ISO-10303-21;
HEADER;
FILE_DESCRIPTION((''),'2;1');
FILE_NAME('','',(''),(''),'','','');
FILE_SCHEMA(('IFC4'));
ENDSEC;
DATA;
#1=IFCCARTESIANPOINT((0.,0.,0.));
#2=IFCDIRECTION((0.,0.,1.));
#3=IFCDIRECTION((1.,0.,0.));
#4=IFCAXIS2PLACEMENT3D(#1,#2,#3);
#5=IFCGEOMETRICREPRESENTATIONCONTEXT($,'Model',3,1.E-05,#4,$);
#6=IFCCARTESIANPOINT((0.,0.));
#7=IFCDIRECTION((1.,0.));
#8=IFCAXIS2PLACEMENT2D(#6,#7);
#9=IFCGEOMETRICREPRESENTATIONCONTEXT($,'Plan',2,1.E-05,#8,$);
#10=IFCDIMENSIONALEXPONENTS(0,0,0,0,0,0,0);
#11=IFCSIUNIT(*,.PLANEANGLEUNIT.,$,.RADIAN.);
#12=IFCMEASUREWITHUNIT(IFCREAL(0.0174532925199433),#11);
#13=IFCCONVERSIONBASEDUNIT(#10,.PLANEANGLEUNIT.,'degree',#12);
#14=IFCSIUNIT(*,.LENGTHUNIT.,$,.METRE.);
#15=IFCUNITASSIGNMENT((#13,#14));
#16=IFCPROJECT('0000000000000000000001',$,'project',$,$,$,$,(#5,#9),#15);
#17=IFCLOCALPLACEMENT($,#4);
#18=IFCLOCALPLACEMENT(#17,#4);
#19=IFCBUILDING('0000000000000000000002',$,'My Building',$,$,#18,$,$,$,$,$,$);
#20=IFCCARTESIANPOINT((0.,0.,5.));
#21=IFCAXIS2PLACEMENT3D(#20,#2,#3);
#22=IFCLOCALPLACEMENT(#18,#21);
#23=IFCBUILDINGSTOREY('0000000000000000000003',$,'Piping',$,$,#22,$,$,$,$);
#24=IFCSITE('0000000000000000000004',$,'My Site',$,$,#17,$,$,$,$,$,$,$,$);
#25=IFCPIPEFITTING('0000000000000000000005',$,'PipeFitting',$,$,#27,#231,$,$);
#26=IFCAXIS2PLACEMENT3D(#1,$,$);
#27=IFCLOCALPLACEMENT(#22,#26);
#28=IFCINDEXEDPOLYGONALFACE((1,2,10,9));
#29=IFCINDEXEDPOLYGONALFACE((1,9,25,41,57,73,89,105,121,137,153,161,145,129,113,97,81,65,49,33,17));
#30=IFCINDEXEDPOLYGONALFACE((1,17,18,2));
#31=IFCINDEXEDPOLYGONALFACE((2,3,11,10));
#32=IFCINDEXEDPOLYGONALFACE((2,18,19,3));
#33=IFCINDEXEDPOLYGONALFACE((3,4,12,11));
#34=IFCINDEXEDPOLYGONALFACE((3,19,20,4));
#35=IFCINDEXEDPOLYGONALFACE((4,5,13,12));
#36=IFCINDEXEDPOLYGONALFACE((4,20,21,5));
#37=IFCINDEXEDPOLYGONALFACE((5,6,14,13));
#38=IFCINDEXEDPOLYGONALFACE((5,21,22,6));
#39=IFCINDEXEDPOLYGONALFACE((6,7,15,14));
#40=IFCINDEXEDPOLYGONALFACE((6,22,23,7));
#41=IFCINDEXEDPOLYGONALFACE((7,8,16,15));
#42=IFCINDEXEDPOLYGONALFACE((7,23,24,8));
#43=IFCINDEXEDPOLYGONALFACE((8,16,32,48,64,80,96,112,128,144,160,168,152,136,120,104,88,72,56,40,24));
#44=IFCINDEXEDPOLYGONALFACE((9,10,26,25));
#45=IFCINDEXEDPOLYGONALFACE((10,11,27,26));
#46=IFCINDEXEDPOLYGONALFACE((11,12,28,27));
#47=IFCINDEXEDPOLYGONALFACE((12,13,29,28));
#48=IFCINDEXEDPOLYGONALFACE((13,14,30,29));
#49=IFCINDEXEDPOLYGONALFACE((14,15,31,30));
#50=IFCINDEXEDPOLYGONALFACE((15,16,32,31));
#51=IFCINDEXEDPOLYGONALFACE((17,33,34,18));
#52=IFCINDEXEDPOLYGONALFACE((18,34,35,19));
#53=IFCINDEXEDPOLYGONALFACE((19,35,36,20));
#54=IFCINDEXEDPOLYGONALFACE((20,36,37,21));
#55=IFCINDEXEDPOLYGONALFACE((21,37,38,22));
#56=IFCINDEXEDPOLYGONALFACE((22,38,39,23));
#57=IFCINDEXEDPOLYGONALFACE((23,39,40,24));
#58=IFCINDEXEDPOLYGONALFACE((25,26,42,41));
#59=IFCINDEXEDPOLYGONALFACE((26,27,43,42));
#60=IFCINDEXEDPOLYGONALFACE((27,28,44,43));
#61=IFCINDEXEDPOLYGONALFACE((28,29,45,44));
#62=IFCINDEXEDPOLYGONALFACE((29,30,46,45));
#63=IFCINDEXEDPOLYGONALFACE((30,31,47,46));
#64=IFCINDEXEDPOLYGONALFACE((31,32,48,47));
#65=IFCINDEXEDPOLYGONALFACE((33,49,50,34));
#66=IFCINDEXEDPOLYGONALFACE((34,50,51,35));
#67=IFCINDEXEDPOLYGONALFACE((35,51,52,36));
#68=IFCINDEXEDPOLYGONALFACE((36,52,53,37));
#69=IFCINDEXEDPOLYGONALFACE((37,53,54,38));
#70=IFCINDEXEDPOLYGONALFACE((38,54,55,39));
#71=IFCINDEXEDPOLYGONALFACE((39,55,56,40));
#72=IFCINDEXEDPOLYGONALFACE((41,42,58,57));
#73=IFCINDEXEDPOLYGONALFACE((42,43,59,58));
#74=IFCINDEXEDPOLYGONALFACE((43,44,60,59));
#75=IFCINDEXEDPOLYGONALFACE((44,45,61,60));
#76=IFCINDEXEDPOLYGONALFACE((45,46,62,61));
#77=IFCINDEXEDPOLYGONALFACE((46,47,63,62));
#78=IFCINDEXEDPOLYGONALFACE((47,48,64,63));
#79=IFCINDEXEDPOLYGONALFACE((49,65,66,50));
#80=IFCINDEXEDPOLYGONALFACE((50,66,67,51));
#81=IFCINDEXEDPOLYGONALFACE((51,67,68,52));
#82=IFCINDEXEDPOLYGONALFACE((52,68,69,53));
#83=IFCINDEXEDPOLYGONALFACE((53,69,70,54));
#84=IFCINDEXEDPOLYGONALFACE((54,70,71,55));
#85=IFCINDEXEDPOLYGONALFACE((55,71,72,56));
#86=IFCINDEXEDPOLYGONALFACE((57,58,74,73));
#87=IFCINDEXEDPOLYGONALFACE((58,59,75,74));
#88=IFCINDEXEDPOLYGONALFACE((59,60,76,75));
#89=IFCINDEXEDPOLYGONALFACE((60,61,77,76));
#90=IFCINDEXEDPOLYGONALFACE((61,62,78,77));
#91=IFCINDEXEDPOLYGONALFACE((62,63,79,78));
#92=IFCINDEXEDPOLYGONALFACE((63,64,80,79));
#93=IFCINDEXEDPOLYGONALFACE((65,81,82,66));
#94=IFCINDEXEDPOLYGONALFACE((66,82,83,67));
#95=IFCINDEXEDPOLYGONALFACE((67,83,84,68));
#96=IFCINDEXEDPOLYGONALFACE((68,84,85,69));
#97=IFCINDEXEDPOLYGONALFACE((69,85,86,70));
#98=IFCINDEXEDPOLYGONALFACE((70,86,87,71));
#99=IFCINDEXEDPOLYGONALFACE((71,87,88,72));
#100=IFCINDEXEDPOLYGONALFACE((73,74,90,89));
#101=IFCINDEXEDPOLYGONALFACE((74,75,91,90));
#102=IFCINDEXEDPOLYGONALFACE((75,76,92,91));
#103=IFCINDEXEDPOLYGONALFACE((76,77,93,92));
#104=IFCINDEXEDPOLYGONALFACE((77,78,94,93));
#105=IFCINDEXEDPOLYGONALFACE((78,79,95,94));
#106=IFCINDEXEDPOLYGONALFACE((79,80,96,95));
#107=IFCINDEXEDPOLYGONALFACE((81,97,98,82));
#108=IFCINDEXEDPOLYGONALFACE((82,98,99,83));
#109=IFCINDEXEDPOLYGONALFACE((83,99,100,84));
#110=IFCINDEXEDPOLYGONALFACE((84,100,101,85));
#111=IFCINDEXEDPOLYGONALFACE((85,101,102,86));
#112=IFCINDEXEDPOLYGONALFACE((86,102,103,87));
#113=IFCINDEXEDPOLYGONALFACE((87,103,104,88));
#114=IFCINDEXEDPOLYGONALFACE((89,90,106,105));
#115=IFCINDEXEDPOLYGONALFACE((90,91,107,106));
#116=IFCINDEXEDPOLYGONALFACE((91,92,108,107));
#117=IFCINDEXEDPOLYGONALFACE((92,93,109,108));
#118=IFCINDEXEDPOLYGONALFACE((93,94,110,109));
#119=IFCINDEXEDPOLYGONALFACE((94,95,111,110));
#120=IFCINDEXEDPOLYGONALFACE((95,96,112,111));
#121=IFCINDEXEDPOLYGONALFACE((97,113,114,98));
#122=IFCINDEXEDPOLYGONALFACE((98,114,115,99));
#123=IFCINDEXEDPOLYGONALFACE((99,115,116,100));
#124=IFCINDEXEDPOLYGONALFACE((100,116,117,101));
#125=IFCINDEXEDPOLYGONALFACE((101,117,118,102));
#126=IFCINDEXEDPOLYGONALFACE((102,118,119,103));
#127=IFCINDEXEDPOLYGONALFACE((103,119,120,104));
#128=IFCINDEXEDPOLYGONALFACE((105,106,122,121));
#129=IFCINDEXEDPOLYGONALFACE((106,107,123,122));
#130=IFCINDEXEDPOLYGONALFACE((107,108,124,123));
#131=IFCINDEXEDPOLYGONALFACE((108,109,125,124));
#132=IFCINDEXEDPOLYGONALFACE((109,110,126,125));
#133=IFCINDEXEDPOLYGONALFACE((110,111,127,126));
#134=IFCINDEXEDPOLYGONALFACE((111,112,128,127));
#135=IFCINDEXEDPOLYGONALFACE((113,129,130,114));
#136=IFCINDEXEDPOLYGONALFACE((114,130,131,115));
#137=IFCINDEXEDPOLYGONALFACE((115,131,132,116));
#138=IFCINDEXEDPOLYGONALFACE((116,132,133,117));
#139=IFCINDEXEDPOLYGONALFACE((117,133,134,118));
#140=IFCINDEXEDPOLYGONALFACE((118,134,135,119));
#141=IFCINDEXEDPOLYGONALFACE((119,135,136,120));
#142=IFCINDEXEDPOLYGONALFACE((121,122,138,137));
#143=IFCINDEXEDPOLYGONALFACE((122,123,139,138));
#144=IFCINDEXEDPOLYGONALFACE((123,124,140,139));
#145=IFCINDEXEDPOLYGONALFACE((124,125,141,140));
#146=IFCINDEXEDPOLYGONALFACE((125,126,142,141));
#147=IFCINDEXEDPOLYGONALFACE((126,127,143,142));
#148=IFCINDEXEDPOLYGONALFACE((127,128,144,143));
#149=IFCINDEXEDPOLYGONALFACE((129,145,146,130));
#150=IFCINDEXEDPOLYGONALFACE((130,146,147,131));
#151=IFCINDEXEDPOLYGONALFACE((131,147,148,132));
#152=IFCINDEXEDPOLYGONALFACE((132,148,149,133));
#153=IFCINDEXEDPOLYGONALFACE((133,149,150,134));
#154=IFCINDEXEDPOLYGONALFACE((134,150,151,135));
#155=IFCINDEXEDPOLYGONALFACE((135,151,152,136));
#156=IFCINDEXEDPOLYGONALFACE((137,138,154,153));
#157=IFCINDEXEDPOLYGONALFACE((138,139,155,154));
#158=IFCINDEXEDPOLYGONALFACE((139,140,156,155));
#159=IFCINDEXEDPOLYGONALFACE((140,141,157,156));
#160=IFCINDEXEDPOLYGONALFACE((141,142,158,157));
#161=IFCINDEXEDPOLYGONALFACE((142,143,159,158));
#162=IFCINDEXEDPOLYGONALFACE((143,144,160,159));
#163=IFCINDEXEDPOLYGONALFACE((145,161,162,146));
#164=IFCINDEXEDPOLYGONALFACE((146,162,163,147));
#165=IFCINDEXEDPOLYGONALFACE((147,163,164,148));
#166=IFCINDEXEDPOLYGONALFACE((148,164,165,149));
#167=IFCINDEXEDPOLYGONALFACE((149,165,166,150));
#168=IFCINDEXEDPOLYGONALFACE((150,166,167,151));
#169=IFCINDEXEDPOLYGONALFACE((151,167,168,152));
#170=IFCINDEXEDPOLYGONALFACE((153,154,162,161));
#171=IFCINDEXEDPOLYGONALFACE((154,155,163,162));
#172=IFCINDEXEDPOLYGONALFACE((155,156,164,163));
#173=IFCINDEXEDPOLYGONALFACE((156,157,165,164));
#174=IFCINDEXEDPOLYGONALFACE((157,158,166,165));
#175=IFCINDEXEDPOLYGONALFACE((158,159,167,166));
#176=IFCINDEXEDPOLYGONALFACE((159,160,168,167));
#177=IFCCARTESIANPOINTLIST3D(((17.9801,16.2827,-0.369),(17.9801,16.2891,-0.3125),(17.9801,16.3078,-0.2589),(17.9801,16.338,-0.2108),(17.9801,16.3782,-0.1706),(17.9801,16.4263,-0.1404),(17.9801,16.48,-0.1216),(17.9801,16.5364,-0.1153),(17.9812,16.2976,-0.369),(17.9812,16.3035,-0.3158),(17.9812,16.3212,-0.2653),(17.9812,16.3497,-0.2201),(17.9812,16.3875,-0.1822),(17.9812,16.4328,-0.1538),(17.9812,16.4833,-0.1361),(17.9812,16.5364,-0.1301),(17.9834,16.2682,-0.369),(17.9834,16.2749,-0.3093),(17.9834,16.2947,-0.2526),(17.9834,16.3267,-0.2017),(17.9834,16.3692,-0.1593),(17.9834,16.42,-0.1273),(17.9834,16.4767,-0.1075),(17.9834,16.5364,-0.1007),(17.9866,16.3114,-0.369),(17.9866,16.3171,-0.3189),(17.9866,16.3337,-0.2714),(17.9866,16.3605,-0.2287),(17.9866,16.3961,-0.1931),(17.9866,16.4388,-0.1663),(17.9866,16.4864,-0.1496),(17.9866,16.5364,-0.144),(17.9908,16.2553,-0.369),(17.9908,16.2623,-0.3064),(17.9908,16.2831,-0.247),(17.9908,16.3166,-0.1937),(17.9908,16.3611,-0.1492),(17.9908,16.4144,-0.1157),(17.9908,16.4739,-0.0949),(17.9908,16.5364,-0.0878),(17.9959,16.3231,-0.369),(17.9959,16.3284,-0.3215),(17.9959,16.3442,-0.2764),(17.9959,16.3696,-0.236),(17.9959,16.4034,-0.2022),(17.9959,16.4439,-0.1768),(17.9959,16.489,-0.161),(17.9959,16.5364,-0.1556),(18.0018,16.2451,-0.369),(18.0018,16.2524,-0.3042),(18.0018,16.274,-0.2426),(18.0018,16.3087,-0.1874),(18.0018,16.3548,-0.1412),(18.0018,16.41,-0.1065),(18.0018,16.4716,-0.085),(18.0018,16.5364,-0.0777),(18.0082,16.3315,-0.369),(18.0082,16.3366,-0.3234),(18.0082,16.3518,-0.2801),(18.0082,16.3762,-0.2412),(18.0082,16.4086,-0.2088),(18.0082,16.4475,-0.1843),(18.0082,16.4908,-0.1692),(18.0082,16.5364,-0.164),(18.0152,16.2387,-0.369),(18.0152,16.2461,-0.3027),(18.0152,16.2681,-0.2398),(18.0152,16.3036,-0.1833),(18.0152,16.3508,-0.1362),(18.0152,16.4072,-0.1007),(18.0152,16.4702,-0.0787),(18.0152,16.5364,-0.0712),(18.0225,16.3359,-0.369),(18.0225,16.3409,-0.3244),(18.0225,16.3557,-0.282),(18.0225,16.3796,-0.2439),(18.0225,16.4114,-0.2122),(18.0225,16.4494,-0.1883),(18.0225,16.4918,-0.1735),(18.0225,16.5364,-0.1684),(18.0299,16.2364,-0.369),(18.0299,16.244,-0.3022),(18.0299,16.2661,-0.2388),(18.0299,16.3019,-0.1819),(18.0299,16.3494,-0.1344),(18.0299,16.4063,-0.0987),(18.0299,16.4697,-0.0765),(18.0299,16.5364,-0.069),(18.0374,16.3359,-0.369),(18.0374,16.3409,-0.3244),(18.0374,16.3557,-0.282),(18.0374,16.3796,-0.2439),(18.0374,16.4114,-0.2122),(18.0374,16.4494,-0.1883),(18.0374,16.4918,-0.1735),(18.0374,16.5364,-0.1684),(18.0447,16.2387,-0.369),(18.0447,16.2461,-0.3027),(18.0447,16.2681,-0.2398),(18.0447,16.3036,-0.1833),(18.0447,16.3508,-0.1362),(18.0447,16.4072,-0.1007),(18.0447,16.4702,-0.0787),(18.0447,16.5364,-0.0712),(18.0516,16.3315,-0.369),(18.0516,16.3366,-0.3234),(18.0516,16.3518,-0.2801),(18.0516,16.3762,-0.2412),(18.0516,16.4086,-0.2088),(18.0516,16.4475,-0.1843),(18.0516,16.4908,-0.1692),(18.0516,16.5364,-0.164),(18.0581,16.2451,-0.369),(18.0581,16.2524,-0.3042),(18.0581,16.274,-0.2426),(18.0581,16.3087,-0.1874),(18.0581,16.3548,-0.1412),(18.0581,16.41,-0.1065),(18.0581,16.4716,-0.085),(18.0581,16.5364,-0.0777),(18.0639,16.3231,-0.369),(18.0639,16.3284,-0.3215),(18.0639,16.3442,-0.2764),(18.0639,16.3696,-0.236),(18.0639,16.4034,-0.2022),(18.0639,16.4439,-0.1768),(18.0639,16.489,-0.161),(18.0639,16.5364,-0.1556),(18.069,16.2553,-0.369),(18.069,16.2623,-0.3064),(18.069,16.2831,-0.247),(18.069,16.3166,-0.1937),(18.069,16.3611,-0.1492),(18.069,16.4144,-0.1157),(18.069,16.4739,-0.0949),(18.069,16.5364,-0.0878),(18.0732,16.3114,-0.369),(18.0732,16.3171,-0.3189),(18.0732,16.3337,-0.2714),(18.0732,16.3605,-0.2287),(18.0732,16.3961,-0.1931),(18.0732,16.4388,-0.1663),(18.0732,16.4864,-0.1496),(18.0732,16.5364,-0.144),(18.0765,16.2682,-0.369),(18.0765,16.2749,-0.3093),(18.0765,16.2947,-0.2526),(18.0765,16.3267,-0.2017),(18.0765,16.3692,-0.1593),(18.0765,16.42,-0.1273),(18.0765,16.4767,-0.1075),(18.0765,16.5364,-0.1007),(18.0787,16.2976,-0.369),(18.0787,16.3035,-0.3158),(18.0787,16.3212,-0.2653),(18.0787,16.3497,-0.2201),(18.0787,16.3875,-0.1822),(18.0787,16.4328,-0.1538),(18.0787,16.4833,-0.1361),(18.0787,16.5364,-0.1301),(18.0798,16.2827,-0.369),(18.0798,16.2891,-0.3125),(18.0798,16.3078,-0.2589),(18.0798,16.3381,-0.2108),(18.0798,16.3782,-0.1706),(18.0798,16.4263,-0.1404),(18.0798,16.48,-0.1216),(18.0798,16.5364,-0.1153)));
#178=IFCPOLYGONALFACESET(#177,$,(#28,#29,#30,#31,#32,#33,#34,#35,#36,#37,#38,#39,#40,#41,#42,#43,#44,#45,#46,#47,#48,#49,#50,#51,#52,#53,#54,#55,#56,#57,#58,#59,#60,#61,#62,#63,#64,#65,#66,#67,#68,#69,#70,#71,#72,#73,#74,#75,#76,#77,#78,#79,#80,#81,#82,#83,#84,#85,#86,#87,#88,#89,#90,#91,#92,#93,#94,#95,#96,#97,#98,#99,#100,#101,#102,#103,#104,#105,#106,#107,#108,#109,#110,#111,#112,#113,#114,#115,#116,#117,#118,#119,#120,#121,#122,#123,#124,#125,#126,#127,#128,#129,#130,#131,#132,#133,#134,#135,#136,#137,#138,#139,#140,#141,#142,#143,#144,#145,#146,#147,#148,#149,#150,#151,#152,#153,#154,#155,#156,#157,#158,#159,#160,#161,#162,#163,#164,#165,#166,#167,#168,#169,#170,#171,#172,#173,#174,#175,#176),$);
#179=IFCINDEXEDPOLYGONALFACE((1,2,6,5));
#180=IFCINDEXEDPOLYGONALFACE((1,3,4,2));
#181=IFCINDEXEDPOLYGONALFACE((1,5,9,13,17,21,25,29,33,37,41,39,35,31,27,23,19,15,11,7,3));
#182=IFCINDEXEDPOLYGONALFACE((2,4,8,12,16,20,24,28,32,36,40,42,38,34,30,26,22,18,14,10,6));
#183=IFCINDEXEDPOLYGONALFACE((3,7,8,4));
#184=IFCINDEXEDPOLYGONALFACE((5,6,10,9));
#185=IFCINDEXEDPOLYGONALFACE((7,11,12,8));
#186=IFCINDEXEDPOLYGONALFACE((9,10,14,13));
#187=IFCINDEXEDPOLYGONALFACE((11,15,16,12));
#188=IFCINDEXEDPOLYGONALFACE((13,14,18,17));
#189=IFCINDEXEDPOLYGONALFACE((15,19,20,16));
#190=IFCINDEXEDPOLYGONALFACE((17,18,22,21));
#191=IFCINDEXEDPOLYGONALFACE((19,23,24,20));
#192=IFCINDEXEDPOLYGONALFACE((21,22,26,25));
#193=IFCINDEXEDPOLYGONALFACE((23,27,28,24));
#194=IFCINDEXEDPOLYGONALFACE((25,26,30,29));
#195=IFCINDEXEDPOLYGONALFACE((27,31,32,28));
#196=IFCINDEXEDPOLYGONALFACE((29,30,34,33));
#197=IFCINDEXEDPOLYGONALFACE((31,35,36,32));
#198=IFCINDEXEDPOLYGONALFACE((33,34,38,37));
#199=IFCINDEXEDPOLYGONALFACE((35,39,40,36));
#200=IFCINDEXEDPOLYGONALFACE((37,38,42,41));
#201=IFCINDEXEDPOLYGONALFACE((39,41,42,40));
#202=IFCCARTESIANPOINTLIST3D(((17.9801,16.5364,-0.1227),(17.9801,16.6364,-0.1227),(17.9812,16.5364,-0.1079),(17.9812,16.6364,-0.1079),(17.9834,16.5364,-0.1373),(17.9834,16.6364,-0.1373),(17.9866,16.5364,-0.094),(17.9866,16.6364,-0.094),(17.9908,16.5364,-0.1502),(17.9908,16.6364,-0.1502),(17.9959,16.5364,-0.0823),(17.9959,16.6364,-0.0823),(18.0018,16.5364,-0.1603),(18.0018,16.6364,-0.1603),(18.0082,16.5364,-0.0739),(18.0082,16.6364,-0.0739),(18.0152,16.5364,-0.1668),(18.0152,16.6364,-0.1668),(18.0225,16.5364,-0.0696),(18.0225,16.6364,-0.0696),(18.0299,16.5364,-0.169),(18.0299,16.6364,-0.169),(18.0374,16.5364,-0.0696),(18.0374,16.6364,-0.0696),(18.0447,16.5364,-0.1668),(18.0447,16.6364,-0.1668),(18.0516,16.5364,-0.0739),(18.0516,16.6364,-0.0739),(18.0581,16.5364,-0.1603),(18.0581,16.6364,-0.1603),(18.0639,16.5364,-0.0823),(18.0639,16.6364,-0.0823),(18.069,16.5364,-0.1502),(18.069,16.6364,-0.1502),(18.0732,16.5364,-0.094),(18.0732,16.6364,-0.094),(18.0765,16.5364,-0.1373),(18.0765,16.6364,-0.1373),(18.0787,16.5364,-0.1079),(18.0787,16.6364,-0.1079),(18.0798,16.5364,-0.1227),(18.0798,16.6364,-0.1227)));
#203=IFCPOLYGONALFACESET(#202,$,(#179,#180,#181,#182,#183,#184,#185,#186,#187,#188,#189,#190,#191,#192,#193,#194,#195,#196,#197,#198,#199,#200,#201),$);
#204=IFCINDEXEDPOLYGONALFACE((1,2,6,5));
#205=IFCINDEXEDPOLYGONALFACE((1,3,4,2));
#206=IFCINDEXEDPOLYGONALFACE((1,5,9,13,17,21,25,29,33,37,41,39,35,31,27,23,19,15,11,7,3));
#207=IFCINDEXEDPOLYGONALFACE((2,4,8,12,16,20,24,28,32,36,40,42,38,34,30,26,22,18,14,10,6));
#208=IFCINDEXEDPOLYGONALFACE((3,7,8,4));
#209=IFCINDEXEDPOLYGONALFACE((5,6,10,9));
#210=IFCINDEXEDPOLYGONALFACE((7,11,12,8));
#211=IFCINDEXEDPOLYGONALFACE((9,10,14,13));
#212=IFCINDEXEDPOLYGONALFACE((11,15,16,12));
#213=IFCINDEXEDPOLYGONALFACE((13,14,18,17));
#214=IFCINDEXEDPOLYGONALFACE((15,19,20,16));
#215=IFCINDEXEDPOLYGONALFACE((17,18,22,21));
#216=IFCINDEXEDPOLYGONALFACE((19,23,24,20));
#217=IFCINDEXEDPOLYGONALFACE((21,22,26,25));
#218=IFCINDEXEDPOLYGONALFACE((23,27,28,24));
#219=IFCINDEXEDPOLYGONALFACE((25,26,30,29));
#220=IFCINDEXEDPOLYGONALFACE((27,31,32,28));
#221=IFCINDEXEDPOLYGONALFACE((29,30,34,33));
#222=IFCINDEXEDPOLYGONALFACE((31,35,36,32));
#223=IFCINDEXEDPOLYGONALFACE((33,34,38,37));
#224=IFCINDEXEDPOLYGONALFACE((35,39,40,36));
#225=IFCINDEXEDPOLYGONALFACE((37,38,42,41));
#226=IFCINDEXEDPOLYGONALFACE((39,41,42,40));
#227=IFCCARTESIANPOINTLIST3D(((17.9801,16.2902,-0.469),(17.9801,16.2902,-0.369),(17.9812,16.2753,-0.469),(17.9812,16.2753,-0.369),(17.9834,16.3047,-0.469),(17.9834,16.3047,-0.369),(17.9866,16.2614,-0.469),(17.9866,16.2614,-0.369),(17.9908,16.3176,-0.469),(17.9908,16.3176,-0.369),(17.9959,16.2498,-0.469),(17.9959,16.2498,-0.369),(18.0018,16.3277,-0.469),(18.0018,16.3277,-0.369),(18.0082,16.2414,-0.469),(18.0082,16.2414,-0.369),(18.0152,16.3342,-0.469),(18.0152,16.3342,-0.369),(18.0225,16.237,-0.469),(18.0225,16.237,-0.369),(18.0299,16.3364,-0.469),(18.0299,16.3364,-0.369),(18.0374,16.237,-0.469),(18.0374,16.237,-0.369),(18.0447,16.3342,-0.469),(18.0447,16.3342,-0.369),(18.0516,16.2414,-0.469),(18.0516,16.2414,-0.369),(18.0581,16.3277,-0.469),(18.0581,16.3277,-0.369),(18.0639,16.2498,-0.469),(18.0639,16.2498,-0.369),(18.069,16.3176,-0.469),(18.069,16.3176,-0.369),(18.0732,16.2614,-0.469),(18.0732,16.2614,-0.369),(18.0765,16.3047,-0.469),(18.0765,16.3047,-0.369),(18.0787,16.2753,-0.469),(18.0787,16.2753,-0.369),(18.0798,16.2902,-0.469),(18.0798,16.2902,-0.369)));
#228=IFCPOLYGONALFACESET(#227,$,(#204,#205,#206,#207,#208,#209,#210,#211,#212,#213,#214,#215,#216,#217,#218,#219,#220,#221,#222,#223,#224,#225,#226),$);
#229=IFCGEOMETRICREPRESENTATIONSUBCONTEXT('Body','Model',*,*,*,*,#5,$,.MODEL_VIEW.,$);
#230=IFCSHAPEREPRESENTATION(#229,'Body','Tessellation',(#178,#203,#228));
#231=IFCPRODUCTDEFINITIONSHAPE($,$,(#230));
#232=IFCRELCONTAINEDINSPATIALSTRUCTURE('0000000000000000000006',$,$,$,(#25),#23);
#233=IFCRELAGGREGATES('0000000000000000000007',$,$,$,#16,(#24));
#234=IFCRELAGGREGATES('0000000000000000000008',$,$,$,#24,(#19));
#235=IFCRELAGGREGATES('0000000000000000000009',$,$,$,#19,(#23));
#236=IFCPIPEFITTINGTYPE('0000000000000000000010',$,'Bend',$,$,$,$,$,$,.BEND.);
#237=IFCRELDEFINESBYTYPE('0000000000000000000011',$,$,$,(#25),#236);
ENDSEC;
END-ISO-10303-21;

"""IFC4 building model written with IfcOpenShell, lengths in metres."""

from ifc_helpers import new_model, entity, si_unit, converted_unit, frame, origin_with_axes, origin_2d_with_axis, place, context, subcontext, project, spatial, circle, extrude, source, transform, mapped, type_object, type_shapes, element, save


model = new_model("IFC4")

# Units and contexts
model_context = context("Model", 3, precision=1e-05, world=origin_with_axes())
plan_context = context("Plan", 2, precision=1e-05, world=origin_2d_with_axis())
body_context = subcontext(model_context, "Body", "Model", "MODEL_VIEW")
ifc_project = project(units=[converted_unit("PLANEANGLEUNIT", "degree", entity("IfcReal", 0.0174532925199433), si_unit("PLANEANGLEUNIT", "RADIAN"), dimensions=[0, 0, 0, 0, 0, 0, 0]), si_unit("LENGTHUNIT", "METRE")], contexts=[model_context, plan_context])

# Site, building, storey
site_placement = place(None, origin_with_axes())
site = spatial("IfcSite", under=ifc_project, at=site_placement, Name="My Site")
building_placement = place(site_placement, origin_with_axes())
building = spatial("IfcBuilding", under=site, at=building_placement, Name="My Building")
storey_placement = place(building_placement, frame((0.0, 0.0, 5.0), z_axis=(0.0, 0.0, 1.0), x_axis=(1.0, 0.0, 0.0)))
storey = spatial("IfcBuildingStorey", under=building, at=storey_placement, Name="Piping")

# Pipe fitting
pipe_fitting_type_1 = type_object("IfcPipeFittingType", Name="Bend", PredefinedType="BEND")
shared_shape = source(origin_with_axes(), body_context, "Body", "SolidModel", [
    entity("IfcSweptDiskSolid", entity("IfcIndexedPolyCurve", entity("IfcCartesianPointList3D", [[0.0, 0.0, -0.1], [0.0732, 0.0, -0.2768], [0.25, 0.0, -0.35]]), [entity("IfcArcIndex", [1, 2, 3])]), 0.05),
    extrude(circle(Radius=0.05), origin_with_axes(), (0.0, 0.0, -1.0), 0.1),
    extrude(circle(Radius=0.05), frame((0.25, 0.0, -0.35), z_axis=(1.0, 0.0, 0.0), x_axis=(0.0, 0.0, 1.0)), (0.0, 0.0, 1.0), 0.1),
])
type_shapes(pipe_fitting_type_1, [shared_shape])
for number, where, z_axis, x_axis, name in (
    (1, (18.0299, 16.6364, -0.119), (-0.00006, 1.0, 0.0), (0.0, 0.0, -1.0), "PipeFitting"),
):
    element("IfcPipeFitting", number, at=place(storey_placement, frame(where, z_axis=z_axis, x_axis=x_axis)), inside=storey, type_object=pipe_fitting_type_1, Name=name, context=body_context, shape_type="MappedRepresentation", body=[
        mapped(shared_shape, transform((0.0, 0.0, 0.0), x_axis=(1.0, 0.0, 0.0), y_axis=(0.0, 1.0, 0.0), z_axis=(0.0, 0.0, 1.0), scale=1.0)),
    ])

save(model, "model.ifc")
